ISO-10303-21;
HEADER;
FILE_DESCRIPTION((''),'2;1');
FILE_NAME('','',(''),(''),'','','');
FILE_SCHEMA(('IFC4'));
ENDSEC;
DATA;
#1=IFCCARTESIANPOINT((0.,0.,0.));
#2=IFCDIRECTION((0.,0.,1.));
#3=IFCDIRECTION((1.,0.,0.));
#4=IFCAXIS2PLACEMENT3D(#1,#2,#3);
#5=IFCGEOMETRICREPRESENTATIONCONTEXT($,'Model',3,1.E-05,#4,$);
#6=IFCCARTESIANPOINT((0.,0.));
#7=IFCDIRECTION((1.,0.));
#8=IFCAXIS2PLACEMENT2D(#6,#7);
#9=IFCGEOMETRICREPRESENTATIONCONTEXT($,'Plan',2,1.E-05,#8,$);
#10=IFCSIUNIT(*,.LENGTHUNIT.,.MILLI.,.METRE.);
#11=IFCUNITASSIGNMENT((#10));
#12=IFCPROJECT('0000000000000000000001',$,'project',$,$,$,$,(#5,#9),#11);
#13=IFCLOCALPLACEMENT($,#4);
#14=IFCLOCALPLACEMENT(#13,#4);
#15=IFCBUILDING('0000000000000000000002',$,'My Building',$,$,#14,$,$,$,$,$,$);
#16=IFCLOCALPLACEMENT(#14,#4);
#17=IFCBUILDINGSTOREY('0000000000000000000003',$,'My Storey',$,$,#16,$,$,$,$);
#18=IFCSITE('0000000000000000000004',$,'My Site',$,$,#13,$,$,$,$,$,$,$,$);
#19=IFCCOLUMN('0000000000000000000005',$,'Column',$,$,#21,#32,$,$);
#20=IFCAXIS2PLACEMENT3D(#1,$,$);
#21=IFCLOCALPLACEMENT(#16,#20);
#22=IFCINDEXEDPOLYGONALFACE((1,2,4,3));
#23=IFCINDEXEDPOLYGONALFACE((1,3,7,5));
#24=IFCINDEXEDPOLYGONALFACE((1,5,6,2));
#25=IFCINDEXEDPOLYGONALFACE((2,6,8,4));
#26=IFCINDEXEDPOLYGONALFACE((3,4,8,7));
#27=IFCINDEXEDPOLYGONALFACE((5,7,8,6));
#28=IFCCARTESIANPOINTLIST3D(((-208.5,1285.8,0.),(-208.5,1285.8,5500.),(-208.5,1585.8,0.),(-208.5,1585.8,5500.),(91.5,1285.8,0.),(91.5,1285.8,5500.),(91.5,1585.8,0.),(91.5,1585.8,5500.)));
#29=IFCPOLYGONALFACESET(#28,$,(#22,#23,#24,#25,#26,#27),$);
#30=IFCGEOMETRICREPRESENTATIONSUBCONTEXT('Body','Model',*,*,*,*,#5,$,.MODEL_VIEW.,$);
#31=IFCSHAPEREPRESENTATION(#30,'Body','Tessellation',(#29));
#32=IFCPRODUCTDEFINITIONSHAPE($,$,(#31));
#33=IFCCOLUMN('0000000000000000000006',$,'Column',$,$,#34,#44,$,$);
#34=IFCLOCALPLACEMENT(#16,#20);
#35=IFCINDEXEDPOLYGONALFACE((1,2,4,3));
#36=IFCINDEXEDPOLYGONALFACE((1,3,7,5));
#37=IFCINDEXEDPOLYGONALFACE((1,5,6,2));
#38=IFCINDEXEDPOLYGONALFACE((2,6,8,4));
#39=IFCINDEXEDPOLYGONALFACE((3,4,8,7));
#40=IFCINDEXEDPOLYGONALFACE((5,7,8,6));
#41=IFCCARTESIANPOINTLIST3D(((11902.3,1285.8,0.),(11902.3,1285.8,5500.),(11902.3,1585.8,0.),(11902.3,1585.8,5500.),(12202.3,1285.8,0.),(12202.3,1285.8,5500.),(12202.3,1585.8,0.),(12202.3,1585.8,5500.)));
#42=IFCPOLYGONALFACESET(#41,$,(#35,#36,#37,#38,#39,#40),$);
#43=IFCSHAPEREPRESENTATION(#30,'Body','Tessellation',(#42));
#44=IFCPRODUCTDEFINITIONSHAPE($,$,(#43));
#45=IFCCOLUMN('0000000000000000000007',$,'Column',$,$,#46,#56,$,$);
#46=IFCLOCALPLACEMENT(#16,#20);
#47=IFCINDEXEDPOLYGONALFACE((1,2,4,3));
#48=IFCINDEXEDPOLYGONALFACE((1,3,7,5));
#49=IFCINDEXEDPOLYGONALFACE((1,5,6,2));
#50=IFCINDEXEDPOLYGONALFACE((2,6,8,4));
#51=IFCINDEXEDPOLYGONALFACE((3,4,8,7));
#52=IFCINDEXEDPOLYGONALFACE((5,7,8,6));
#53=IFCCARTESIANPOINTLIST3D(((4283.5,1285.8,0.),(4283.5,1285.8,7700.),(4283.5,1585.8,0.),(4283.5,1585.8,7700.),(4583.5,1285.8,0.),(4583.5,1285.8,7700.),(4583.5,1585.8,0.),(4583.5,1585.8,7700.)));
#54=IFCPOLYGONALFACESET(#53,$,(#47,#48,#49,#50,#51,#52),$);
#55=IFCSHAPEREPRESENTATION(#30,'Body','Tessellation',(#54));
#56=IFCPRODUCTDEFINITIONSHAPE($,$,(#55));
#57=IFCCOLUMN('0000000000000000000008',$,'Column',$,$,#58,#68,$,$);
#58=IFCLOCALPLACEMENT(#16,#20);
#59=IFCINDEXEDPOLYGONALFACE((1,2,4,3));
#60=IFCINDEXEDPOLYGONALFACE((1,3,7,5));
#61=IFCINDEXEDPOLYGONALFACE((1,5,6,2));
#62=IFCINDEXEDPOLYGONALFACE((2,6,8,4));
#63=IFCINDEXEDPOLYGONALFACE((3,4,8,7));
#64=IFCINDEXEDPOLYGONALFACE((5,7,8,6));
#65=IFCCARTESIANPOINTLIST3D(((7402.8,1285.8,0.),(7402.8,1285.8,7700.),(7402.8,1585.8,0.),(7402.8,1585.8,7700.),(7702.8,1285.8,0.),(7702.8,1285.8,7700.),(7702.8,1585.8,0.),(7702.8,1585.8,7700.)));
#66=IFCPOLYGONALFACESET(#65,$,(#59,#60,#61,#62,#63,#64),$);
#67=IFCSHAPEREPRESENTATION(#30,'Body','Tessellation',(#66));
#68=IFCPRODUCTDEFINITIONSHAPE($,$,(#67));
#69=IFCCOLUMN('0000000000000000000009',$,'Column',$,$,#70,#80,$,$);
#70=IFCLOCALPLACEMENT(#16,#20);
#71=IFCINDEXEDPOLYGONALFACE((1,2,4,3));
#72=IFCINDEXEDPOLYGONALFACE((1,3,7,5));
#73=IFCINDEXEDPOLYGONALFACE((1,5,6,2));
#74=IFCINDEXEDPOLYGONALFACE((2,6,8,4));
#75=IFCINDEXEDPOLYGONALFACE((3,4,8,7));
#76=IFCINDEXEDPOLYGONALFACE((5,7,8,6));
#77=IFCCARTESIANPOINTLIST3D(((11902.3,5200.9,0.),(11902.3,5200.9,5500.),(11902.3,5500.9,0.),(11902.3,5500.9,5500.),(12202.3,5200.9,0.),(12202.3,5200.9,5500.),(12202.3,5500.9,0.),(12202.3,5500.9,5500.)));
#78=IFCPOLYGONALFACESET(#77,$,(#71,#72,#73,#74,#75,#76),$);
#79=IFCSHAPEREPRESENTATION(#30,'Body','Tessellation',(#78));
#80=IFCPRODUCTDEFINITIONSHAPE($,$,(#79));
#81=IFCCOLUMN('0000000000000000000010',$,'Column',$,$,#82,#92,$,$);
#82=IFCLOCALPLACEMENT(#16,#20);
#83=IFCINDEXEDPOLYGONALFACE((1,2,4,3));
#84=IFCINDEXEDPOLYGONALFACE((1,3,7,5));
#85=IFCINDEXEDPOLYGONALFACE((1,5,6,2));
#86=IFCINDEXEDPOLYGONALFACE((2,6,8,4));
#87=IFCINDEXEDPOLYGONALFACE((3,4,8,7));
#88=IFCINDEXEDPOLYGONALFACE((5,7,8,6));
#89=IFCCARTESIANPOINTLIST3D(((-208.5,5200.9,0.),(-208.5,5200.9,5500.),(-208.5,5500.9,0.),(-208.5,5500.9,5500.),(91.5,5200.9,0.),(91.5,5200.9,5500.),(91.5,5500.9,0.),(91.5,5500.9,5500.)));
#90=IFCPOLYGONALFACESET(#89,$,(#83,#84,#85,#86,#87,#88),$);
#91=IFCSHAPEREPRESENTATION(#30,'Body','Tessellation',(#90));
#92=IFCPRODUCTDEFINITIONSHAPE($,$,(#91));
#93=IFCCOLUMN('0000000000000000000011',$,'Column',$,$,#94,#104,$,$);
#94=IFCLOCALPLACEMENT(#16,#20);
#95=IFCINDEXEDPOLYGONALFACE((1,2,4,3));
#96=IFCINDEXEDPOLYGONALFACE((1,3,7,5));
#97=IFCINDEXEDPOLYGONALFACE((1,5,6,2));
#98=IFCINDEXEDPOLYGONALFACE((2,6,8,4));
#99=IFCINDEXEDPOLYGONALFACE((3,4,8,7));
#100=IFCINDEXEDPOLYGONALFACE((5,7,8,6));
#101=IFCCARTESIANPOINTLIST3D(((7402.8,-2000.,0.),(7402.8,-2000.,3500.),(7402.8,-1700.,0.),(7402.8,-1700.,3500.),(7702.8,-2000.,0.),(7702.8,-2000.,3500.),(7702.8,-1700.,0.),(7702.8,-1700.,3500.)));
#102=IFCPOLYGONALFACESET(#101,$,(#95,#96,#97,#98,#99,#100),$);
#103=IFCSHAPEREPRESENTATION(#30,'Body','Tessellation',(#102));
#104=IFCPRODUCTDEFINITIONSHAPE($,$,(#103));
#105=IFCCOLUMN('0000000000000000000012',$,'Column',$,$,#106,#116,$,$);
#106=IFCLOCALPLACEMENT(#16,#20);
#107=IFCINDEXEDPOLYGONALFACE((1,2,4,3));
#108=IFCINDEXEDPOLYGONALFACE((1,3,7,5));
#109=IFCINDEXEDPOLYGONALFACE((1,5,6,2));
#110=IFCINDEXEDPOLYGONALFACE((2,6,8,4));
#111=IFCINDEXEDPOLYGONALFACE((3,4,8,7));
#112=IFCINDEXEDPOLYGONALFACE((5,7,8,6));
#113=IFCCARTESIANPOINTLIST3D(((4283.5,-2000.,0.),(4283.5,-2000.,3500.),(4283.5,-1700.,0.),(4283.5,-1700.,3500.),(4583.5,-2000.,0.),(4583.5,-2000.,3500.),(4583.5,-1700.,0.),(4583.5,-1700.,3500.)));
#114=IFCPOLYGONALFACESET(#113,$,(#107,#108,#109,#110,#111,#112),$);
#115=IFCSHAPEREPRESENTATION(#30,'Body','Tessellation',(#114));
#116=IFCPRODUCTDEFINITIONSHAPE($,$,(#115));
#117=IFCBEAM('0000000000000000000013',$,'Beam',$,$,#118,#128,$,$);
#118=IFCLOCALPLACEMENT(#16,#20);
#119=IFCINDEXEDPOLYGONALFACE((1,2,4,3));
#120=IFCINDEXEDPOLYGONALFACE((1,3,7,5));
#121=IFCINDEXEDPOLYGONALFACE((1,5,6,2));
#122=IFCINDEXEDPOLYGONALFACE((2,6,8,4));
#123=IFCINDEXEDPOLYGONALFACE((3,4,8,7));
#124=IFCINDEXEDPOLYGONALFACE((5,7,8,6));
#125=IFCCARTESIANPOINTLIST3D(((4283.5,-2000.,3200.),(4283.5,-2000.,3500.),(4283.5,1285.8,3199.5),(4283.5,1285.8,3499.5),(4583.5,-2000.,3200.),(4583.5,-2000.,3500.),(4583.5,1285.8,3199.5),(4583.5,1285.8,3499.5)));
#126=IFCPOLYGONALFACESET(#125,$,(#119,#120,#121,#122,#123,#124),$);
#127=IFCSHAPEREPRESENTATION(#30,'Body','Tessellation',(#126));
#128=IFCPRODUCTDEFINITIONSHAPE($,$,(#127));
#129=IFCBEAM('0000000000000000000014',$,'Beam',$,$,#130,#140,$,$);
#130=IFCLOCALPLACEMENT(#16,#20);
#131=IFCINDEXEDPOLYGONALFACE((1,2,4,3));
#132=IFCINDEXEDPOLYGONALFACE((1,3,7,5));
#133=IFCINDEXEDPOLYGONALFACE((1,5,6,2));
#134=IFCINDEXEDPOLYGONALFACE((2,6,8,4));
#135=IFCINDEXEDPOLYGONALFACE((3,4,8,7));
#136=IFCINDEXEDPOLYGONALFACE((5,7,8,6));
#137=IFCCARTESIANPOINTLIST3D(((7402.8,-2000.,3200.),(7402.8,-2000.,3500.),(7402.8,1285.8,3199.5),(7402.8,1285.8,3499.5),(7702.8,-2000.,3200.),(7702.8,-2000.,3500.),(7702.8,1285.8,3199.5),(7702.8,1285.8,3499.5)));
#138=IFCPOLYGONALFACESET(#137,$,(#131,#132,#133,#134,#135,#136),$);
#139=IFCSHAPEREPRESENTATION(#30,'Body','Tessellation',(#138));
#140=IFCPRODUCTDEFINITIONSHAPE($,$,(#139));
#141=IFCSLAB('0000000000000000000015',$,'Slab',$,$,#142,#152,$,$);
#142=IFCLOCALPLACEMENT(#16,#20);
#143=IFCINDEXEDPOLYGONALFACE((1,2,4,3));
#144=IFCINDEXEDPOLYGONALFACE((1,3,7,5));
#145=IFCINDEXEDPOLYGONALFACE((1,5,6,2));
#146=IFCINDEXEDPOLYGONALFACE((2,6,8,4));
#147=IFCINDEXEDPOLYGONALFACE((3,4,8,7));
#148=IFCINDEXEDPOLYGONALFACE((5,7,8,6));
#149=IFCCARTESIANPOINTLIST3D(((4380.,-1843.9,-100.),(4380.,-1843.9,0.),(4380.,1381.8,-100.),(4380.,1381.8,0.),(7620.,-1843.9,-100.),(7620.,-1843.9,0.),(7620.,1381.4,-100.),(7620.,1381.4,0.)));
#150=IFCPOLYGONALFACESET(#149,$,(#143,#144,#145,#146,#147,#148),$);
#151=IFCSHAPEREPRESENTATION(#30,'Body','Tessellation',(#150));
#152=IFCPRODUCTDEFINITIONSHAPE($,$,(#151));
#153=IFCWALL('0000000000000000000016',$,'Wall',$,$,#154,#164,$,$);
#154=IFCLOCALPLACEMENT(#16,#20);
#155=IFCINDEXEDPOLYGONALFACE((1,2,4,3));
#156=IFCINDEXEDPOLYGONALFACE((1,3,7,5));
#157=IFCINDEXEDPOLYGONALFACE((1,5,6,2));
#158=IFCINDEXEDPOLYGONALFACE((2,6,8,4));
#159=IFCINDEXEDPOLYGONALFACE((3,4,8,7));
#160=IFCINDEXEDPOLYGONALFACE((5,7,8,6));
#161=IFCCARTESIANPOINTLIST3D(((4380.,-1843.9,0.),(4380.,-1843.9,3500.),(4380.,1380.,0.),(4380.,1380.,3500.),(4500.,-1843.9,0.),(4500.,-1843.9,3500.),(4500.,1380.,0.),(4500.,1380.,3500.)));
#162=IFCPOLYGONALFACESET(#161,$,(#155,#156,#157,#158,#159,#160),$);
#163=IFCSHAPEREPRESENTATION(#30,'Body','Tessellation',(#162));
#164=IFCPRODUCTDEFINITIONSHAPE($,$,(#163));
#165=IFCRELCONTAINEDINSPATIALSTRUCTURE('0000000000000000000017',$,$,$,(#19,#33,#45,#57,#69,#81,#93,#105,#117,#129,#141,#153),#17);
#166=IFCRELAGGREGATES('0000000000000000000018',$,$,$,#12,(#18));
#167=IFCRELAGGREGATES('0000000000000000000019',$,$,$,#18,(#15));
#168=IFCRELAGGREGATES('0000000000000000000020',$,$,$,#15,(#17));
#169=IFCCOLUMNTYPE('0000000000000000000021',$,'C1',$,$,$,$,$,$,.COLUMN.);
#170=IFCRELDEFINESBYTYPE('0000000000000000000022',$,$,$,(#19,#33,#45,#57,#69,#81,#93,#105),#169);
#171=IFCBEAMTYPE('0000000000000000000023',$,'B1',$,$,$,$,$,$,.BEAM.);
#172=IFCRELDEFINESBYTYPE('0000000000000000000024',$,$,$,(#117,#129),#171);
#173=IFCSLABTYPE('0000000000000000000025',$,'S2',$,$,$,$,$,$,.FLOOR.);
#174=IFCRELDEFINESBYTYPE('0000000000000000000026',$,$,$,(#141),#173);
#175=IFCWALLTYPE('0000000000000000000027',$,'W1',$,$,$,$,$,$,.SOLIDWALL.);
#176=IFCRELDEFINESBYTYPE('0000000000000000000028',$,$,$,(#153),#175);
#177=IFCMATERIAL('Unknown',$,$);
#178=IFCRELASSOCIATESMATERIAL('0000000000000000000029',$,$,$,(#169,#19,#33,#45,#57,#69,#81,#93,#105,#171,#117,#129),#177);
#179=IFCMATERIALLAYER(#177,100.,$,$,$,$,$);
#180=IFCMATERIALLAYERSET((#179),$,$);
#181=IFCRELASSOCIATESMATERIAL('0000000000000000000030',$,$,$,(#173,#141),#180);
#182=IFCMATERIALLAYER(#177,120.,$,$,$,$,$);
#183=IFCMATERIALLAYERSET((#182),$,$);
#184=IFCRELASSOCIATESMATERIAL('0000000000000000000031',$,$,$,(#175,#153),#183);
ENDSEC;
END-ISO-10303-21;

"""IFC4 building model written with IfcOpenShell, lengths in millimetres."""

from ifc_helpers import new_model, si_unit, frame, origin_with_axes, origin_2d_with_axis, place, context, subcontext, project, spatial, line, indexed_curve, rectangle, outline, extrude, material, layer, layer_set, layer_usage, material_profile, profile_set, profile_usage, type_object, element, save


model = new_model("IFC4")

# Units and contexts
model_context = context("Model", 3, precision=1e-05, world=origin_with_axes())
plan_context = context("Plan", 2, precision=1e-05, world=origin_2d_with_axis())
body_context_1 = subcontext(model_context, "Body", "Model", "MODEL_VIEW")
ifc_project = project(units=[si_unit("LENGTHUNIT", "METRE", prefix="MILLI")], contexts=[model_context, plan_context])

# Site, building, storey
site_placement = place(None, origin_with_axes())
site = spatial("IfcSite", under=ifc_project, at=site_placement, Name="My Site")
building_placement = place(site_placement, origin_with_axes())
building = spatial("IfcBuilding", under=site, at=building_placement, Name="My Building")
storey_placement = place(building_placement, origin_with_axes())
storey = spatial("IfcBuildingStorey", under=building, at=storey_placement, Name="My Storey")

# Columns
ifc_material = material(Name="Unknown")
ifc_material_profile_1 = material_profile(ifc_material, rectangle(XDim=300.0, YDim=300.0))
ifc_profile_set_1 = profile_set([ifc_material_profile_1])
ifc_profile_usage_1 = profile_usage(ifc_profile_set_1, cardinal=5)
column_type = type_object("IfcColumnType", Name="C1", PredefinedType="COLUMN", material=ifc_profile_set_1)
column_1_placement = place(storey_placement, frame((-58.5, 1435.8, 0.0), z_axis=(0.0, 0.0, 1.0), x_axis=(1.0, 0.0, 0.0)))
element("IfcColumn", 1, at=column_1_placement, inside=storey, type_object=column_type, material=ifc_profile_usage_1, Name="Column", context=body_context_1, shape_type="SweptSolid", body=[
    extrude(rectangle(XDim=300.0, YDim=300.0), origin_with_axes(), (0.0, 0.0, 1.0), 5500.0),
])
ifc_profile_usage_2 = profile_usage(ifc_profile_set_1, cardinal=5)
column_2_placement = place(storey_placement, frame((12052.3, 1435.8, 0.0), z_axis=(0.0, 0.0, 1.0), x_axis=(1.0, 0.0, 0.0)))
element("IfcColumn", 2, at=column_2_placement, inside=storey, type_object=column_type, material=ifc_profile_usage_2, Name="Column", context=body_context_1, shape_type="SweptSolid", body=[
    extrude(rectangle(XDim=300.0, YDim=300.0), origin_with_axes(), (0.0, 0.0, 1.0), 5500.0),
])
ifc_profile_usage_3 = profile_usage(ifc_profile_set_1, cardinal=5)
column_3_placement = place(storey_placement, frame((4433.5, 1435.8, 0.0), z_axis=(0.0, 0.0, 1.0), x_axis=(1.0, 0.0, 0.0)))
element("IfcColumn", 3, at=column_3_placement, inside=storey, type_object=column_type, material=ifc_profile_usage_3, Name="Column", context=body_context_1, shape_type="SweptSolid", body=[
    extrude(rectangle(XDim=300.0, YDim=300.0), origin_with_axes(), (0.0, 0.0, 1.0), 7700.0),
])
ifc_profile_usage_4 = profile_usage(ifc_profile_set_1, cardinal=5)
column_4_placement = place(storey_placement, frame((7552.8, 1435.8, 0.0), z_axis=(0.0, 0.0, 1.0), x_axis=(1.0, 0.0, 0.0)))
element("IfcColumn", 4, at=column_4_placement, inside=storey, type_object=column_type, material=ifc_profile_usage_4, Name="Column", context=body_context_1, shape_type="SweptSolid", body=[
    extrude(rectangle(XDim=300.0, YDim=300.0), origin_with_axes(), (0.0, 0.0, 1.0), 7700.0),
])
ifc_profile_usage_5 = profile_usage(ifc_profile_set_1, cardinal=5)
column_5_placement = place(storey_placement, frame((12052.3, 5350.9, 0.0), z_axis=(0.0, 0.0, 1.0), x_axis=(1.0, 0.0, 0.0)))
element("IfcColumn", 5, at=column_5_placement, inside=storey, type_object=column_type, material=ifc_profile_usage_5, Name="Column", context=body_context_1, shape_type="SweptSolid", body=[
    extrude(rectangle(XDim=300.0, YDim=300.0), origin_with_axes(), (0.0, 0.0, 1.0), 5500.0),
])
ifc_profile_usage_6 = profile_usage(ifc_profile_set_1, cardinal=5)
column_6_placement = place(storey_placement, frame((-58.5, 5350.9, 0.0), z_axis=(0.0, 0.0, 1.0), x_axis=(1.0, 0.0, 0.0)))
element("IfcColumn", 6, at=column_6_placement, inside=storey, type_object=column_type, material=ifc_profile_usage_6, Name="Column", context=body_context_1, shape_type="SweptSolid", body=[
    extrude(rectangle(XDim=300.0, YDim=300.0), origin_with_axes(), (0.0, 0.0, 1.0), 5500.0),
])
ifc_profile_usage_7 = profile_usage(ifc_profile_set_1, cardinal=5)
column_7_placement = place(storey_placement, frame((7552.8, -1850.0, 0.0), z_axis=(0.0, 0.0, 1.0), x_axis=(1.0, 0.0, 0.0)))
element("IfcColumn", 7, at=column_7_placement, inside=storey, type_object=column_type, material=ifc_profile_usage_7, Name="Column", context=body_context_1, shape_type="SweptSolid", body=[
    extrude(rectangle(XDim=300.0, YDim=300.0), origin_with_axes(), (0.0, 0.0, 1.0), 3500.0),
])
ifc_profile_usage_8 = profile_usage(ifc_profile_set_1, cardinal=5)
column_8_placement = place(storey_placement, frame((4433.5, -1850.0, 0.0), z_axis=(0.0, 0.0, 1.0), x_axis=(1.0, 0.0, 0.0)))
element("IfcColumn", 8, at=column_8_placement, inside=storey, type_object=column_type, material=ifc_profile_usage_8, Name="Column", context=body_context_1, shape_type="SweptSolid", body=[
    extrude(rectangle(XDim=300.0, YDim=300.0), origin_with_axes(), (0.0, 0.0, 1.0), 3500.0),
])

# Beams
ifc_material_profile_2 = material_profile(ifc_material, rectangle(XDim=300.0, YDim=300.0))
ifc_profile_set_2 = profile_set([ifc_material_profile_2])
ifc_profile_usage_9 = profile_usage(ifc_profile_set_2, cardinal=9)
beam_type = type_object("IfcBeamType", Name="B1", PredefinedType="BEAM", material=ifc_profile_set_2)
beam_1_placement = place(storey_placement, frame((4283.5, 1285.8, 3499.5), z_axis=(0.0, -1.0, 0.000138), x_axis=(1.0, 0.0, 0.0)))
element("IfcBeam", 9, at=beam_1_placement, inside=storey, type_object=beam_type, material=ifc_profile_usage_9, Name="Beam", context=body_context_1, shape_type="SweptSolid", body=[
    extrude(rectangle(XDim=300.0, YDim=300.0), frame((150.0, -150.0, 0.0), z_axis=(0.0, 0.0, 1.0), x_axis=(1.0, 0.0, 0.0)), (0.0, 0.0, 1.0), 3285.8),
])
ifc_profile_usage_10 = profile_usage(ifc_profile_set_2, cardinal=9)
beam_2_placement = place(storey_placement, frame((7402.8, 1285.8, 3499.5), z_axis=(0.0, -1.0, 0.000138), x_axis=(1.0, 0.0, 0.0)))
element("IfcBeam", 10, at=beam_2_placement, inside=storey, type_object=beam_type, material=ifc_profile_usage_10, Name="Beam", context=body_context_1, shape_type="SweptSolid", body=[
    extrude(rectangle(XDim=300.0, YDim=300.0), frame((150.0, -150.0, 0.0), z_axis=(0.0, 0.0, 1.0), x_axis=(1.0, 0.0, 0.0)), (0.0, 0.0, 1.0), 3285.8),
])

# Slab
ifc_layer_1 = layer(ifc_material, 100.0)
ifc_layer_set_1 = layer_set([ifc_layer_1])
ifc_layer_usage_1 = layer_usage(ifc_layer_set_1, "AXIS3", "POSITIVE", -100.0)
slab_type = type_object("IfcSlabType", Name="S2", PredefinedType="FLOOR", material=ifc_layer_set_1)
slab_placement = place(storey_placement, frame((4380.0, 0.0, 0.0), z_axis=(0.0, 0.0, 1.0), x_axis=(1.0, 0.0, 0.0)))
element("IfcSlab", 11, at=slab_placement, inside=storey, type_object=slab_type, material=ifc_layer_usage_1, Name="Slab", context=body_context_1, shape_type="SweptSolid", body=[
    extrude(outline(indexed_curve([(0.0, 1381.8), (3240.0, 1381.4), (3240.0, -1843.9), (0.0, -1843.9), (0.0, 1381.8)])), frame((0.0, 0.0, -100.0), z_axis=(0.0, 0.0, 1.0), x_axis=(1.0, 0.0, 0.0)), (0.0, 0.0, 1.0), 100.0),
])

# Wall
ifc_layer_2 = layer(ifc_material, 120.0)
ifc_layer_set_2 = layer_set([ifc_layer_2])
ifc_layer_usage_2 = layer_usage(ifc_layer_set_2, "AXIS2", "POSITIVE", 0.0)
wall_type_1 = type_object("IfcWallType", Name="W1", PredefinedType="SOLIDWALL", material=ifc_layer_set_2)
wall_1_placement = place(storey_placement, frame((4500.0, -1843.9, 0.0), z_axis=(0.0, 0.0, 1.0), x_axis=(0.0, 1.0, 0.0)))
element("IfcWall", 12, at=wall_1_placement, inside=storey, type_object=wall_type_1, material=ifc_layer_usage_2, Name="Wall", context=body_context_1, shape_type="SweptSolid", body=[
    extrude(outline(indexed_curve([(0.0, 0.0), (0.0, 120.0), (3223.9, 120.0), (3223.9, 0.0)], segments=[line(1, 2, 3, 4, 1)])), origin_with_axes(), (0.0, 0.0, 1.0), 3500.0),
])

save(model, "model.ifc")
